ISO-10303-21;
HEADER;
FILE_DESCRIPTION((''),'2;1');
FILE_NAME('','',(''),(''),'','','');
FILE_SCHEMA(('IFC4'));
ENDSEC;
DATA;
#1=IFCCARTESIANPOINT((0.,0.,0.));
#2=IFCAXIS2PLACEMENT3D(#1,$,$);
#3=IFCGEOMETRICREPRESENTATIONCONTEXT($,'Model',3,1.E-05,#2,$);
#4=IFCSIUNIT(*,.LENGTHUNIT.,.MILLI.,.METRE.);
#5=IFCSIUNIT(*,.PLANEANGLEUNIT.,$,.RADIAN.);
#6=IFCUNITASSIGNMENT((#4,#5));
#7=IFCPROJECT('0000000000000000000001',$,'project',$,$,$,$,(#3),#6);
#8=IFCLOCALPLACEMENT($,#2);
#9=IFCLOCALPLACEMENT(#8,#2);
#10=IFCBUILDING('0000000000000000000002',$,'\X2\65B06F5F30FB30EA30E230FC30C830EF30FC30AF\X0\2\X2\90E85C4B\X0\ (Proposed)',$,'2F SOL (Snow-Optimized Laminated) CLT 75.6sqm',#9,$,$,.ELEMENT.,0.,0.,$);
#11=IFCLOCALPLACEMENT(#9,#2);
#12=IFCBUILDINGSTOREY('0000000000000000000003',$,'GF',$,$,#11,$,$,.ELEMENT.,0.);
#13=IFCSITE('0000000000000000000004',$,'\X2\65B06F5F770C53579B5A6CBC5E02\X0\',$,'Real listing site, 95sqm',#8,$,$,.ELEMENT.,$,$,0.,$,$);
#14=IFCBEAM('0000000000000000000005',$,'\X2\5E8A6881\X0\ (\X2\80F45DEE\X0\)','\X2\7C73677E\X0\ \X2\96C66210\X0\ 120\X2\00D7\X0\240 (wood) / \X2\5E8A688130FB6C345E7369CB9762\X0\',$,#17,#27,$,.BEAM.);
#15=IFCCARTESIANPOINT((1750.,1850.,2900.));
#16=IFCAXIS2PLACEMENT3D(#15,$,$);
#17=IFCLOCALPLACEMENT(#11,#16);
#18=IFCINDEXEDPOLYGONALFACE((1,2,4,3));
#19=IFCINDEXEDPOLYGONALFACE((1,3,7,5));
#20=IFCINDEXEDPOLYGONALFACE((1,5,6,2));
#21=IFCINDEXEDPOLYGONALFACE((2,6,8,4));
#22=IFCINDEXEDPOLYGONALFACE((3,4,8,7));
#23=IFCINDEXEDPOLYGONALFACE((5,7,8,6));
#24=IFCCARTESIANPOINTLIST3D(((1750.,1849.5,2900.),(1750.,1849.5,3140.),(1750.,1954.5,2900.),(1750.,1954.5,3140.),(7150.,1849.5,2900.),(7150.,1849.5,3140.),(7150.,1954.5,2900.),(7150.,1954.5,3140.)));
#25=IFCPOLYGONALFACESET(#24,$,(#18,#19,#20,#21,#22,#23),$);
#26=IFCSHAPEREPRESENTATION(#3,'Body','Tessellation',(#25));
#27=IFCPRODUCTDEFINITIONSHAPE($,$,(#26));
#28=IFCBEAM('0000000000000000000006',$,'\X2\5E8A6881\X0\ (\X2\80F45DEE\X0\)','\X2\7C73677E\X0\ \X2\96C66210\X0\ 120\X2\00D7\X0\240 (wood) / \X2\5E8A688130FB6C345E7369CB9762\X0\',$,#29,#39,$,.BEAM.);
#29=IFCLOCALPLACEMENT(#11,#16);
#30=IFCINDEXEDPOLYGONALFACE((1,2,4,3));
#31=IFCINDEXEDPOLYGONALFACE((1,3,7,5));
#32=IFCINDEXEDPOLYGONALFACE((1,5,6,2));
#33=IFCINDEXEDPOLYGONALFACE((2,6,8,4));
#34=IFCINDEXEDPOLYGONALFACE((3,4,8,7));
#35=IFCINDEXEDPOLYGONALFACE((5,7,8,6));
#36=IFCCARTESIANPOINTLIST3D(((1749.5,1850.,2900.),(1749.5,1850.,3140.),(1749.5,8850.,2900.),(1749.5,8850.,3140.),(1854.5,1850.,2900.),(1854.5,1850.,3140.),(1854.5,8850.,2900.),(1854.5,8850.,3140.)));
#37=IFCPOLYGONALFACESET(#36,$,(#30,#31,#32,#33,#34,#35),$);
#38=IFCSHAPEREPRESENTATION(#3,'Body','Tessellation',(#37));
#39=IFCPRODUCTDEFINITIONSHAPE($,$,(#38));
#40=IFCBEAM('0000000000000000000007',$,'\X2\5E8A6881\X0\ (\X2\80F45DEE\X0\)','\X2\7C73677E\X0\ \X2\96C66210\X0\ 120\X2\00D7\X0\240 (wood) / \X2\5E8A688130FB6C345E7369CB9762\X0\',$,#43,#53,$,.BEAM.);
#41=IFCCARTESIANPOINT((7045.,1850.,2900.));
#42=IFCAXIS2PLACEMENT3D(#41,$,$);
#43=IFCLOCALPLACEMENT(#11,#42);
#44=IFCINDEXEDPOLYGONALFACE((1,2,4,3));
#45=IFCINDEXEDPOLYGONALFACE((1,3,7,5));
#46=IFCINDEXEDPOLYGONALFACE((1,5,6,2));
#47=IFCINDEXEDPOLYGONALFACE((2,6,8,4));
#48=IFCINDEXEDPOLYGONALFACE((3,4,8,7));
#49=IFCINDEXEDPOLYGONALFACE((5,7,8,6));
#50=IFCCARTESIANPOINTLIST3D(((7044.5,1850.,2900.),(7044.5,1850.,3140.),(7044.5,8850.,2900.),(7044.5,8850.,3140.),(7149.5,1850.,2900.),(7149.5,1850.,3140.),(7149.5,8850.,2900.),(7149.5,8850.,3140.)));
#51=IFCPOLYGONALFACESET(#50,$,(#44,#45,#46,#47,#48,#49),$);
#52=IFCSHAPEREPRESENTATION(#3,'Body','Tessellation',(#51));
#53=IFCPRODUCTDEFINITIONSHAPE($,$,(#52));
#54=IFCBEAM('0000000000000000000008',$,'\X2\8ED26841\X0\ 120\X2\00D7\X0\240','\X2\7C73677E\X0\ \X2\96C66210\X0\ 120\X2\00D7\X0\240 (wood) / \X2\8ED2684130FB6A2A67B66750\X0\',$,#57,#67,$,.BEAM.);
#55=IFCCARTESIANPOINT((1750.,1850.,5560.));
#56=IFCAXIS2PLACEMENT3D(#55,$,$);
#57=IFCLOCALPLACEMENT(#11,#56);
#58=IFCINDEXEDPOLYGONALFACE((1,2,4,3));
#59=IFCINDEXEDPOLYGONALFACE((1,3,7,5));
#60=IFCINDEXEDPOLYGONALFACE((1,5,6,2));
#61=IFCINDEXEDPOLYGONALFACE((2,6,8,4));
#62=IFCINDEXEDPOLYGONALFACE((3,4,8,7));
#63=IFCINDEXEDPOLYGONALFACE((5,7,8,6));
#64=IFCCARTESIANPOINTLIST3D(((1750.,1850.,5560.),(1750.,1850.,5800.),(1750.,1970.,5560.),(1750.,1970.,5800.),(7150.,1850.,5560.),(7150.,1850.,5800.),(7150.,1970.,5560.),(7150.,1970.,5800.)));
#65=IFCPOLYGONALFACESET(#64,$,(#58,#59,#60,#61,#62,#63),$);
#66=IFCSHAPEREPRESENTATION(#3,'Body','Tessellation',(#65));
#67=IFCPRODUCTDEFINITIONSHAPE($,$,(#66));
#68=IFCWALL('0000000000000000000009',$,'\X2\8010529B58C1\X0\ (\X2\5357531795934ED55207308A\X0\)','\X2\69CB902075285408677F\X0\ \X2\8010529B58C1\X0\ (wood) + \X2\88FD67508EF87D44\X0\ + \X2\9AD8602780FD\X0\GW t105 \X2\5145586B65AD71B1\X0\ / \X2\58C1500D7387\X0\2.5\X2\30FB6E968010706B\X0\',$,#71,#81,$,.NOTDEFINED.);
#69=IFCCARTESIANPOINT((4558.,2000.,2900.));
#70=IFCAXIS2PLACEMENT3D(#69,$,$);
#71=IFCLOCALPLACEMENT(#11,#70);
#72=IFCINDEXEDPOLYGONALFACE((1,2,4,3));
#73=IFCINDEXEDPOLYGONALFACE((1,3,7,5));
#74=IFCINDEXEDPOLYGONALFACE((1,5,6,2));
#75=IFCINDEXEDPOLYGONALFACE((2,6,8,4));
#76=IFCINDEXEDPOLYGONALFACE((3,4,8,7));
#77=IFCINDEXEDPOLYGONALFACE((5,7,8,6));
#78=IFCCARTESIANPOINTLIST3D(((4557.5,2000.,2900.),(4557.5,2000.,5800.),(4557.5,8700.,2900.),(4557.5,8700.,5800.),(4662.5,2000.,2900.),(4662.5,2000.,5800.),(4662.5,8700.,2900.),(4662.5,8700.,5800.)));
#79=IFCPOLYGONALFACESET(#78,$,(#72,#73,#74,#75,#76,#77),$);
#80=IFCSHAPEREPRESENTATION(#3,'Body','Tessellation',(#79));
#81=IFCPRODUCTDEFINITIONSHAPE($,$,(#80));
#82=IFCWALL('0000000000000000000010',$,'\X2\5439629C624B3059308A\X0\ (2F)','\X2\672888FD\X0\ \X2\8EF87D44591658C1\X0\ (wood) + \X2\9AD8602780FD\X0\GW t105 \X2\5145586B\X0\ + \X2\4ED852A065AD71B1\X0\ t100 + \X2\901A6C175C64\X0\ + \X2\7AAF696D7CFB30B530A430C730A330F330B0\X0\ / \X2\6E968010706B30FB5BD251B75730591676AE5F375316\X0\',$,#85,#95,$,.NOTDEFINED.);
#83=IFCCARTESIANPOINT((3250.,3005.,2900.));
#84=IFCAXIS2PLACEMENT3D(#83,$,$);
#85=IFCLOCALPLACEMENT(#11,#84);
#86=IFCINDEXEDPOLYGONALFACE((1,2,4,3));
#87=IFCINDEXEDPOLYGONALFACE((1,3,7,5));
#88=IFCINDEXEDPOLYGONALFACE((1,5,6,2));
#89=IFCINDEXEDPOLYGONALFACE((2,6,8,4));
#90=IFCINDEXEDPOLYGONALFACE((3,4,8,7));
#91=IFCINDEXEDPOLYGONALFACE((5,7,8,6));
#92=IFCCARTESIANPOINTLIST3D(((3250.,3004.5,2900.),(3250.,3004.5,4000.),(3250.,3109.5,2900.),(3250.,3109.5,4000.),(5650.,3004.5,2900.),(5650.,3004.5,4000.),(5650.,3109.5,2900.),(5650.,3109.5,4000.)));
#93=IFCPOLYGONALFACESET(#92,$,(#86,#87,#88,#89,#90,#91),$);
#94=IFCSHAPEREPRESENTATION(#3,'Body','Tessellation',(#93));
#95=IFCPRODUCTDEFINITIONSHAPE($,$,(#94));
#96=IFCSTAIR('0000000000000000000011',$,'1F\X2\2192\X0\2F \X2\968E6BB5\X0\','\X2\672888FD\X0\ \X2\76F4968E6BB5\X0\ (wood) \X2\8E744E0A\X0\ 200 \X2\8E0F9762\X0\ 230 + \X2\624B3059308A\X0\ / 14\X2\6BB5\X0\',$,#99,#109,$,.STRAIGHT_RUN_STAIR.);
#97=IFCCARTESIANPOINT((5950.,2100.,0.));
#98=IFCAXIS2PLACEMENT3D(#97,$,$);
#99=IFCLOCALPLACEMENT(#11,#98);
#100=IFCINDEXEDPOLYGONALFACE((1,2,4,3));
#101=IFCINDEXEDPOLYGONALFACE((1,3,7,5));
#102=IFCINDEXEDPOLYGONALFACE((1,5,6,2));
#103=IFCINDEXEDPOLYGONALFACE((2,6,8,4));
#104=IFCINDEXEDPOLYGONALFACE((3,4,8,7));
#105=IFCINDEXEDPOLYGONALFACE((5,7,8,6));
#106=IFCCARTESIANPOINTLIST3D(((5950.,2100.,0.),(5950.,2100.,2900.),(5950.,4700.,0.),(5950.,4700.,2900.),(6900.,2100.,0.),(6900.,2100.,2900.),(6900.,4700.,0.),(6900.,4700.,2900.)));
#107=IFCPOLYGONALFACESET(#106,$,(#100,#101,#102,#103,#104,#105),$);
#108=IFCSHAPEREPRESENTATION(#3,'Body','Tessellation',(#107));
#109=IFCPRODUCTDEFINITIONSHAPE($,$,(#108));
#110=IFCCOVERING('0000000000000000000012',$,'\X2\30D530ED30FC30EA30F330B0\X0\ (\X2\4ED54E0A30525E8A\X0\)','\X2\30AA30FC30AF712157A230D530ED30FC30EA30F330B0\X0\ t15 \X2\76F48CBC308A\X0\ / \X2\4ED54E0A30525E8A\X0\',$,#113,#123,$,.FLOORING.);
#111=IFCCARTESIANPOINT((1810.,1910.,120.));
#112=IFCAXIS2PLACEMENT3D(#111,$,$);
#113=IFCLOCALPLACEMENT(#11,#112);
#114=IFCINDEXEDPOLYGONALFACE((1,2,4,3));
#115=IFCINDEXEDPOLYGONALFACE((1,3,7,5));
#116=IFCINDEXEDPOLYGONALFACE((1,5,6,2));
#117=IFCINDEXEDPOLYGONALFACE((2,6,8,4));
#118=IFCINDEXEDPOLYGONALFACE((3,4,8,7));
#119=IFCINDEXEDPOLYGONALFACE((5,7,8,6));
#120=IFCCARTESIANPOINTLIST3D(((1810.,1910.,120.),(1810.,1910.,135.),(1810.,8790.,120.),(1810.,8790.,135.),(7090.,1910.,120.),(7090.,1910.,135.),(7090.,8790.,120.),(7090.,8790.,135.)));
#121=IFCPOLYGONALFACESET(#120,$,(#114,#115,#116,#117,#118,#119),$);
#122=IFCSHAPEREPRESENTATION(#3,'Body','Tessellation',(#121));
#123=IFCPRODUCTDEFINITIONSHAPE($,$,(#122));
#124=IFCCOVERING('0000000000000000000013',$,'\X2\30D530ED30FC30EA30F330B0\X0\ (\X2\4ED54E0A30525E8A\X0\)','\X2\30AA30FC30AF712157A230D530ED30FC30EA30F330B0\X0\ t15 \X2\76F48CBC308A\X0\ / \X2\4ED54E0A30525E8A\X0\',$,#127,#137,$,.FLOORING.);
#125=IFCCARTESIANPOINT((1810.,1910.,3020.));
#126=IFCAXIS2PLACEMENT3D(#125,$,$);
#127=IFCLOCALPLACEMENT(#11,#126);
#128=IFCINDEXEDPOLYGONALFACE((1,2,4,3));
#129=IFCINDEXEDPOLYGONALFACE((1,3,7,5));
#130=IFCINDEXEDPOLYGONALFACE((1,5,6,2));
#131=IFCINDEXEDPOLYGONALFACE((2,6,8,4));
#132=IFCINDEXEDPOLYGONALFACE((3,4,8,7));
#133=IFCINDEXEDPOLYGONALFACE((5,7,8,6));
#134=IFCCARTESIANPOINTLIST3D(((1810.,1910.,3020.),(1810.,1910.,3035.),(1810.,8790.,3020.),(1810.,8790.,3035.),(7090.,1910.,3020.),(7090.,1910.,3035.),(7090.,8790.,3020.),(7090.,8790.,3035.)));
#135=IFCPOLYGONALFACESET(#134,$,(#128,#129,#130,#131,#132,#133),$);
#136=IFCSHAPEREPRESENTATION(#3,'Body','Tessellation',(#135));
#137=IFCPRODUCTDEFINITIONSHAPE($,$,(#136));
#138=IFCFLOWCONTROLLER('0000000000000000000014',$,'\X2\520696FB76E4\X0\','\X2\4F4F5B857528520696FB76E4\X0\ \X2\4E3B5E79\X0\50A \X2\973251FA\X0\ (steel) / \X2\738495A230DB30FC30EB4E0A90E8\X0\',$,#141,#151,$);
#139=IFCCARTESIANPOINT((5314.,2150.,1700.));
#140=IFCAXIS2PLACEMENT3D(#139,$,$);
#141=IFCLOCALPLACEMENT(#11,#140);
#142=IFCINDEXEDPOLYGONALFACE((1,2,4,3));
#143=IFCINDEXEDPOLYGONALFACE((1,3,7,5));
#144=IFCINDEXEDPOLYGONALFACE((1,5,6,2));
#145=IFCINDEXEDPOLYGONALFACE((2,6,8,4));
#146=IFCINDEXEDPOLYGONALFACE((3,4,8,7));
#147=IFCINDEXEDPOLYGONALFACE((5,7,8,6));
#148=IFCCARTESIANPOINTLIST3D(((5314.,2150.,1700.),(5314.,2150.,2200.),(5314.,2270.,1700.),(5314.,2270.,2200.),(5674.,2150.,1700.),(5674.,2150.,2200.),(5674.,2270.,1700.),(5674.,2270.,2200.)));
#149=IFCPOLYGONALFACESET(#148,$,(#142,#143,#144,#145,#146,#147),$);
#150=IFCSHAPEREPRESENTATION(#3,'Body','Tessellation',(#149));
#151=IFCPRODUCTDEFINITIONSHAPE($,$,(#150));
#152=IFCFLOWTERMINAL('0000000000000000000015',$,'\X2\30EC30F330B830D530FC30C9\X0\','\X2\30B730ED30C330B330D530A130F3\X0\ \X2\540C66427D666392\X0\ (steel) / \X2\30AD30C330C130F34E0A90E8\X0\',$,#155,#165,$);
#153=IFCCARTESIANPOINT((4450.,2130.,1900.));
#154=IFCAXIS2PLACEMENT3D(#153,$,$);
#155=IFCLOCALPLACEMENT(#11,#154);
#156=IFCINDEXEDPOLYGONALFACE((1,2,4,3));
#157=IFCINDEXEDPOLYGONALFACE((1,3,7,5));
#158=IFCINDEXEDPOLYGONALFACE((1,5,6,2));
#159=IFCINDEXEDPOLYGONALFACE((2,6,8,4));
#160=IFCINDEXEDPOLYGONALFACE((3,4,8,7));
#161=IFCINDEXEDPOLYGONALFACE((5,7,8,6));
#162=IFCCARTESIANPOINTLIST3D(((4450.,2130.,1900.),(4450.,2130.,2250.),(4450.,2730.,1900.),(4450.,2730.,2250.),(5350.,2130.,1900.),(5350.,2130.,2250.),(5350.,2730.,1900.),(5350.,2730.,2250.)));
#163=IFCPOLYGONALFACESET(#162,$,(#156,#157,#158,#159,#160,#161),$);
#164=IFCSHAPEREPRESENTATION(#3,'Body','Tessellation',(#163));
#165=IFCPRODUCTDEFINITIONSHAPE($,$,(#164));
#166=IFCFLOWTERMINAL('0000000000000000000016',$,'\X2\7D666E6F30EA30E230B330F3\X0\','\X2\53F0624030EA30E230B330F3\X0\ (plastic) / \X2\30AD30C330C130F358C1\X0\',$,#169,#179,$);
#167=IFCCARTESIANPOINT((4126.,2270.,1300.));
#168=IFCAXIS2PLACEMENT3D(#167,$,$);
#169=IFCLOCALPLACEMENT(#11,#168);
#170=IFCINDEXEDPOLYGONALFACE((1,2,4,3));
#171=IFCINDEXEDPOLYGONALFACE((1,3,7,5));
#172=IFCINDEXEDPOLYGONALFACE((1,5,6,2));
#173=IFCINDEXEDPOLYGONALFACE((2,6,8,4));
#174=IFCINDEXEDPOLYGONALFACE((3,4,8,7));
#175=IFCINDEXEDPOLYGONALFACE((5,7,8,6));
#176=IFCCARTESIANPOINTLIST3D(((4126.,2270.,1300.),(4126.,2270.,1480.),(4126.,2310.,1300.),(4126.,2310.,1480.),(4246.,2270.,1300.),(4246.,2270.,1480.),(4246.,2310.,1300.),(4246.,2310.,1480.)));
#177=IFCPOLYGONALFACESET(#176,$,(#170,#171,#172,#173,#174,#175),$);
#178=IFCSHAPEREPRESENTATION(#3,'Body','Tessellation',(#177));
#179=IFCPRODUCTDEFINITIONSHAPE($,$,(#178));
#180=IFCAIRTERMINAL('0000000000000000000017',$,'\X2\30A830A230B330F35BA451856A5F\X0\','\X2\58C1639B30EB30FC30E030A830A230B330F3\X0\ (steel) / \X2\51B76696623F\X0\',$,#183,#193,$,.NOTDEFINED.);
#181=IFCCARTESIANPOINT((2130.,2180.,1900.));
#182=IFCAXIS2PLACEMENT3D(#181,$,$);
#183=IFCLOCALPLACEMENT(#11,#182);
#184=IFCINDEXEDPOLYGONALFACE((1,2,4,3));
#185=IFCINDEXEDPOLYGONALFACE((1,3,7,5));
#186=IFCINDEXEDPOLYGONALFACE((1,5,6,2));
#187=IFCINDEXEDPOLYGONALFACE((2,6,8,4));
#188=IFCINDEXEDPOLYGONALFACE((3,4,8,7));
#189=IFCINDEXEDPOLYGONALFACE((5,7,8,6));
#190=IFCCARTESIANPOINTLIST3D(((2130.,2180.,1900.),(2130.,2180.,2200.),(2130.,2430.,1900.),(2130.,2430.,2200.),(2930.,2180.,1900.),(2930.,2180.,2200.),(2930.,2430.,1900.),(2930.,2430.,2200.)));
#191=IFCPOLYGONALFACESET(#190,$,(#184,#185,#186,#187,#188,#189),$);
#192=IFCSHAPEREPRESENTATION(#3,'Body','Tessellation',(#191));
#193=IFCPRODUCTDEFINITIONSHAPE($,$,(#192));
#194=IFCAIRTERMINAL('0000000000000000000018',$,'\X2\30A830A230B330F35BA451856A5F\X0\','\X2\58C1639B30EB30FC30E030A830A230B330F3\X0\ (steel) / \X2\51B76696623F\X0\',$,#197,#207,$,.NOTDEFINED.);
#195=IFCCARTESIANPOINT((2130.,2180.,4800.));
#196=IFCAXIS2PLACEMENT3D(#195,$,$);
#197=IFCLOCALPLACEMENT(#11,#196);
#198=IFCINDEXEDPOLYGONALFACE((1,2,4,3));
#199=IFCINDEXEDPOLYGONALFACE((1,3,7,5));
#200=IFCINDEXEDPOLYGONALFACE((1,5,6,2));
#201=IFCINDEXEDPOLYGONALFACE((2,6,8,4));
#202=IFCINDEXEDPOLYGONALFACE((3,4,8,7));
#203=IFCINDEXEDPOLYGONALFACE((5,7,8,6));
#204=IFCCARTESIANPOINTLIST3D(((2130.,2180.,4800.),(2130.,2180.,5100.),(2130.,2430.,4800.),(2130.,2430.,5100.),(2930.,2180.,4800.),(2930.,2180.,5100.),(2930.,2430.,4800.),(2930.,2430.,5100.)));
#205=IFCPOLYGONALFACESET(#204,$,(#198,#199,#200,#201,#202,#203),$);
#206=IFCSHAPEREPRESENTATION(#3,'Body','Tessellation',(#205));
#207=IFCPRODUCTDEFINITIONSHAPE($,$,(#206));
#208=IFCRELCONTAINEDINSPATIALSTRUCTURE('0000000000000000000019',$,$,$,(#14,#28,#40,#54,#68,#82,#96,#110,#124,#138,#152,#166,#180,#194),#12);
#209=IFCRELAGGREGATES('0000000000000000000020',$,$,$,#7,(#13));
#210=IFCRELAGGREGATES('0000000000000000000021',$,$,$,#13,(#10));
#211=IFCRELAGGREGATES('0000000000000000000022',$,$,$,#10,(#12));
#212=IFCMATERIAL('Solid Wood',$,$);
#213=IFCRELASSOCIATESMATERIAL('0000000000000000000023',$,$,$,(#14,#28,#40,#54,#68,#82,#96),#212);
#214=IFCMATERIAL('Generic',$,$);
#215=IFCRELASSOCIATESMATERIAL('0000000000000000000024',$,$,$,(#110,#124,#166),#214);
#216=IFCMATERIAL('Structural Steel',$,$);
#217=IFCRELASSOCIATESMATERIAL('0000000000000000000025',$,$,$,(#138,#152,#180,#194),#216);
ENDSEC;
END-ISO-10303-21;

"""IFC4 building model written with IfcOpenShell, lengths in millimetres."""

from ifc_helpers import new_model, si_unit, frame, frame_2d, origin, place, context, project, spatial, rectangle, extrude, material, element, save


model = new_model("IFC4")

# Units and contexts
model_context = context("Model", 3, precision=1e-05, world=origin())
ifc_project = project(units=[si_unit("LENGTHUNIT", "METRE", prefix="MILLI"), si_unit("PLANEANGLEUNIT", "RADIAN")], contexts=[model_context])

# Site, building, storey
site_placement = place(None, origin())
site = spatial("IfcSite", under=ifc_project, at=site_placement, Name="新潟県南魚沼市", ObjectType="Real listing site, 95sqm", CompositionType="ELEMENT", RefElevation=0.0)
building_placement = place(site_placement, origin())
building = spatial("IfcBuilding", under=site, at=building_placement, Name="新潟・リモートワーク2部屋 (Proposed)", ObjectType="2F SOL (Snow-Optimized Laminated) CLT 75.6sqm", CompositionType="ELEMENT", ElevationOfRefHeight=0.0, ElevationOfTerrain=0.0)
storey_placement = place(building_placement, origin())
storey = spatial("IfcBuildingStorey", under=building, at=storey_placement, Name="GF", CompositionType="ELEMENT", Elevation=0.0)

# Shared definitions
ifc_material_1 = material(Name="Solid Wood")

# Beams
beam_1_placement = place(storey_placement, frame((1750.0, 1850.0, 2900.0)))
element("IfcBeam", 1, at=beam_1_placement, inside=storey, material=ifc_material_1, Name="床梁 (胴差)", Description="米松 集成 120×240 (wood) / 床梁・水平構面", PredefinedType="BEAM", context=model_context, shape_type="SweptSolid", body=[
    extrude(rectangle(XDim=5400.0, YDim=105.0, at=frame_2d((2700.0, 52.0))), frame((1750.0, 1850.0, 2900.0)), (0.0, 0.0, 1.0), 240.0),
])
beam_2_placement = place(storey_placement, frame((1750.0, 1850.0, 2900.0)))
element("IfcBeam", 2, at=beam_2_placement, inside=storey, material=ifc_material_1, Name="床梁 (胴差)", Description="米松 集成 120×240 (wood) / 床梁・水平構面", PredefinedType="BEAM", context=model_context, shape_type="SweptSolid", body=[
    extrude(rectangle(XDim=105.0, YDim=7000.0, at=frame_2d((52.0, 3500.0))), frame((1750.0, 1850.0, 2900.0)), (0.0, 0.0, 1.0), 240.0),
])
beam_3_placement = place(storey_placement, frame((7045.0, 1850.0, 2900.0)))
element("IfcBeam", 3, at=beam_3_placement, inside=storey, material=ifc_material_1, Name="床梁 (胴差)", Description="米松 集成 120×240 (wood) / 床梁・水平構面", PredefinedType="BEAM", context=model_context, shape_type="SweptSolid", body=[
    extrude(rectangle(XDim=105.0, YDim=7000.0, at=frame_2d((52.0, 3500.0))), frame((7045.0, 1850.0, 2900.0)), (0.0, 0.0, 1.0), 240.0),
])
beam_4_placement = place(storey_placement, frame((1750.0, 1850.0, 5560.0)))
element("IfcBeam", 4, at=beam_4_placement, inside=storey, material=ifc_material_1, Name="軒桁 120×240", Description="米松 集成 120×240 (wood) / 軒桁・横架材", PredefinedType="BEAM", context=model_context, shape_type="SweptSolid", body=[
    extrude(rectangle(XDim=5400.0, YDim=120.0, at=frame_2d((2700.0, 60.0))), frame((1750.0, 1850.0, 5560.0)), (0.0, 0.0, 1.0), 240.0),
])

# Walls
wall_1_placement = place(storey_placement, frame((4558.0, 2000.0, 2900.0)))
element("IfcWall", 5, at=wall_1_placement, inside=storey, material=ifc_material_1, Name="耐力壁 (南北間仕切り)", Description="構造用合板 耐力壁 (wood) + 製材軸組 + 高性能GW t105 充填断熱 / 壁倍率2.5・準耐火", PredefinedType="NOTDEFINED", context=model_context, shape_type="SweptSolid", body=[
    extrude(rectangle(XDim=105.0, YDim=6700.0, at=frame_2d((52.0, 3350.0))), frame((4558.0, 2000.0, 2900.0)), (0.0, 0.0, 1.0), 2900.0),
])
wall_2_placement = place(storey_placement, frame((3250.0, 3005.0, 2900.0)))
element("IfcWall", 6, at=wall_2_placement, inside=storey, material=ifc_material_1, Name="吹抜手すり (2F)", Description="木製 軸組外壁 (wood) + 高性能GW t105 充填 + 付加断熱 t100 + 通気層 + 窯業系サイディング / 準耐火・寒冷地外皮強化", PredefinedType="NOTDEFINED", context=model_context, shape_type="SweptSolid", body=[
    extrude(rectangle(XDim=2400.0, YDim=105.0, at=frame_2d((1200.0, 52.0))), frame((3250.0, 3005.0, 2900.0)), (0.0, 0.0, 1.0), 1100.0),
])

# Stair
stair_placement = place(storey_placement, frame((5950.0, 2100.0, 0.0)))
element("IfcStair", 7, at=stair_placement, inside=storey, material=ifc_material_1, Name="1F→2F 階段", Description="木製 直階段 (wood) 蹴上 200 踏面 230 + 手すり / 14段", PredefinedType="STRAIGHT_RUN_STAIR", context=model_context, shape_type="SweptSolid", body=[
    extrude(rectangle(XDim=950.0, YDim=2600.0, at=frame_2d((475.0, 1300.0))), frame((5950.0, 2100.0, 0.0)), (0.0, 0.0, 1.0), 2900.0),
])

# Coverings
ifc_material_2 = material(Name="Generic")
covering_1_placement = place(storey_placement, frame((1810.0, 1910.0, 120.0)))
element("IfcCovering", 8, at=covering_1_placement, inside=storey, material=ifc_material_2, Name="フローリング (仕上げ床)", Description="オーク無垢フローリング t15 直貼り / 仕上げ床", PredefinedType="FLOORING", context=model_context, shape_type="SweptSolid", body=[
    extrude(rectangle(XDim=5280.0, YDim=6880.0, at=frame_2d((2640.0, 3440.0))), frame((1810.0, 1910.0, 120.0)), (0.0, 0.0, 1.0), 15.0),
])
covering_2_placement = place(storey_placement, frame((1810.0, 1910.0, 3020.0)))
element("IfcCovering", 9, at=covering_2_placement, inside=storey, material=ifc_material_2, Name="フローリング (仕上げ床)", Description="オーク無垢フローリング t15 直貼り / 仕上げ床", PredefinedType="FLOORING", context=model_context, shape_type="SweptSolid", body=[
    extrude(rectangle(XDim=5280.0, YDim=6880.0, at=frame_2d((2640.0, 3440.0))), frame((1810.0, 1910.0, 3020.0)), (0.0, 0.0, 1.0), 15.0),
])

# Flow controller
ifc_material_3 = material(Name="Structural Steel")
flow_controller_placement = place(storey_placement, frame((5314.0, 2150.0, 1700.0)))
element("IfcFlowController", 10, at=flow_controller_placement, inside=storey, material=ifc_material_3, Name="分電盤", Description="住宅用分電盤 主幹50A 露出 (steel) / 玄関ホール上部", context=model_context, shape_type="SweptSolid", body=[
    extrude(rectangle(XDim=360.0, YDim=120.0, at=frame_2d((180.0, 60.0))), frame((5314.0, 2150.0, 1700.0)), (0.0, 0.0, 1.0), 500.0),
])

# Flow terminals
flow_terminal_1_placement = place(storey_placement, frame((4450.0, 2130.0, 1900.0)))
element("IfcFlowTerminal", 11, at=flow_terminal_1_placement, inside=storey, material=ifc_material_3, Name="レンジフード", Description="シロッコファン 同時給排 (steel) / キッチン上部", context=model_context, shape_type="SweptSolid", body=[
    extrude(rectangle(XDim=900.0, YDim=600.0, at=frame_2d((450.0, 300.0))), frame((4450.0, 2130.0, 1900.0)), (0.0, 0.0, 1.0), 350.0),
])
flow_terminal_2_placement = place(storey_placement, frame((4126.0, 2270.0, 1300.0)))
element("IfcFlowTerminal", 12, at=flow_terminal_2_placement, inside=storey, material=ifc_material_2, Name="給湯リモコン", Description="台所リモコン (plastic) / キッチン壁", context=model_context, shape_type="SweptSolid", body=[
    extrude(rectangle(XDim=120.0, YDim=40.0, at=frame_2d((60.0, 20.0))), frame((4126.0, 2270.0, 1300.0)), (0.0, 0.0, 1.0), 180.0),
])

# Air terminals
air_terminal_1_placement = place(storey_placement, frame((2130.0, 2180.0, 1900.0)))
element("IfcAirTerminal", 13, at=air_terminal_1_placement, inside=storey, material=ifc_material_3, Name="エアコン室内機", Description="壁掛ルームエアコン (steel) / 冷暖房", PredefinedType="NOTDEFINED", context=model_context, shape_type="SweptSolid", body=[
    extrude(rectangle(XDim=800.0, YDim=250.0, at=frame_2d((400.0, 125.0))), frame((2130.0, 2180.0, 1900.0)), (0.0, 0.0, 1.0), 300.0),
])
air_terminal_2_placement = place(storey_placement, frame((2130.0, 2180.0, 4800.0)))
element("IfcAirTerminal", 14, at=air_terminal_2_placement, inside=storey, material=ifc_material_3, Name="エアコン室内機", Description="壁掛ルームエアコン (steel) / 冷暖房", PredefinedType="NOTDEFINED", context=model_context, shape_type="SweptSolid", body=[
    extrude(rectangle(XDim=800.0, YDim=250.0, at=frame_2d((400.0, 125.0))), frame((2130.0, 2180.0, 4800.0)), (0.0, 0.0, 1.0), 300.0),
])

save(model, "model.ifc")
